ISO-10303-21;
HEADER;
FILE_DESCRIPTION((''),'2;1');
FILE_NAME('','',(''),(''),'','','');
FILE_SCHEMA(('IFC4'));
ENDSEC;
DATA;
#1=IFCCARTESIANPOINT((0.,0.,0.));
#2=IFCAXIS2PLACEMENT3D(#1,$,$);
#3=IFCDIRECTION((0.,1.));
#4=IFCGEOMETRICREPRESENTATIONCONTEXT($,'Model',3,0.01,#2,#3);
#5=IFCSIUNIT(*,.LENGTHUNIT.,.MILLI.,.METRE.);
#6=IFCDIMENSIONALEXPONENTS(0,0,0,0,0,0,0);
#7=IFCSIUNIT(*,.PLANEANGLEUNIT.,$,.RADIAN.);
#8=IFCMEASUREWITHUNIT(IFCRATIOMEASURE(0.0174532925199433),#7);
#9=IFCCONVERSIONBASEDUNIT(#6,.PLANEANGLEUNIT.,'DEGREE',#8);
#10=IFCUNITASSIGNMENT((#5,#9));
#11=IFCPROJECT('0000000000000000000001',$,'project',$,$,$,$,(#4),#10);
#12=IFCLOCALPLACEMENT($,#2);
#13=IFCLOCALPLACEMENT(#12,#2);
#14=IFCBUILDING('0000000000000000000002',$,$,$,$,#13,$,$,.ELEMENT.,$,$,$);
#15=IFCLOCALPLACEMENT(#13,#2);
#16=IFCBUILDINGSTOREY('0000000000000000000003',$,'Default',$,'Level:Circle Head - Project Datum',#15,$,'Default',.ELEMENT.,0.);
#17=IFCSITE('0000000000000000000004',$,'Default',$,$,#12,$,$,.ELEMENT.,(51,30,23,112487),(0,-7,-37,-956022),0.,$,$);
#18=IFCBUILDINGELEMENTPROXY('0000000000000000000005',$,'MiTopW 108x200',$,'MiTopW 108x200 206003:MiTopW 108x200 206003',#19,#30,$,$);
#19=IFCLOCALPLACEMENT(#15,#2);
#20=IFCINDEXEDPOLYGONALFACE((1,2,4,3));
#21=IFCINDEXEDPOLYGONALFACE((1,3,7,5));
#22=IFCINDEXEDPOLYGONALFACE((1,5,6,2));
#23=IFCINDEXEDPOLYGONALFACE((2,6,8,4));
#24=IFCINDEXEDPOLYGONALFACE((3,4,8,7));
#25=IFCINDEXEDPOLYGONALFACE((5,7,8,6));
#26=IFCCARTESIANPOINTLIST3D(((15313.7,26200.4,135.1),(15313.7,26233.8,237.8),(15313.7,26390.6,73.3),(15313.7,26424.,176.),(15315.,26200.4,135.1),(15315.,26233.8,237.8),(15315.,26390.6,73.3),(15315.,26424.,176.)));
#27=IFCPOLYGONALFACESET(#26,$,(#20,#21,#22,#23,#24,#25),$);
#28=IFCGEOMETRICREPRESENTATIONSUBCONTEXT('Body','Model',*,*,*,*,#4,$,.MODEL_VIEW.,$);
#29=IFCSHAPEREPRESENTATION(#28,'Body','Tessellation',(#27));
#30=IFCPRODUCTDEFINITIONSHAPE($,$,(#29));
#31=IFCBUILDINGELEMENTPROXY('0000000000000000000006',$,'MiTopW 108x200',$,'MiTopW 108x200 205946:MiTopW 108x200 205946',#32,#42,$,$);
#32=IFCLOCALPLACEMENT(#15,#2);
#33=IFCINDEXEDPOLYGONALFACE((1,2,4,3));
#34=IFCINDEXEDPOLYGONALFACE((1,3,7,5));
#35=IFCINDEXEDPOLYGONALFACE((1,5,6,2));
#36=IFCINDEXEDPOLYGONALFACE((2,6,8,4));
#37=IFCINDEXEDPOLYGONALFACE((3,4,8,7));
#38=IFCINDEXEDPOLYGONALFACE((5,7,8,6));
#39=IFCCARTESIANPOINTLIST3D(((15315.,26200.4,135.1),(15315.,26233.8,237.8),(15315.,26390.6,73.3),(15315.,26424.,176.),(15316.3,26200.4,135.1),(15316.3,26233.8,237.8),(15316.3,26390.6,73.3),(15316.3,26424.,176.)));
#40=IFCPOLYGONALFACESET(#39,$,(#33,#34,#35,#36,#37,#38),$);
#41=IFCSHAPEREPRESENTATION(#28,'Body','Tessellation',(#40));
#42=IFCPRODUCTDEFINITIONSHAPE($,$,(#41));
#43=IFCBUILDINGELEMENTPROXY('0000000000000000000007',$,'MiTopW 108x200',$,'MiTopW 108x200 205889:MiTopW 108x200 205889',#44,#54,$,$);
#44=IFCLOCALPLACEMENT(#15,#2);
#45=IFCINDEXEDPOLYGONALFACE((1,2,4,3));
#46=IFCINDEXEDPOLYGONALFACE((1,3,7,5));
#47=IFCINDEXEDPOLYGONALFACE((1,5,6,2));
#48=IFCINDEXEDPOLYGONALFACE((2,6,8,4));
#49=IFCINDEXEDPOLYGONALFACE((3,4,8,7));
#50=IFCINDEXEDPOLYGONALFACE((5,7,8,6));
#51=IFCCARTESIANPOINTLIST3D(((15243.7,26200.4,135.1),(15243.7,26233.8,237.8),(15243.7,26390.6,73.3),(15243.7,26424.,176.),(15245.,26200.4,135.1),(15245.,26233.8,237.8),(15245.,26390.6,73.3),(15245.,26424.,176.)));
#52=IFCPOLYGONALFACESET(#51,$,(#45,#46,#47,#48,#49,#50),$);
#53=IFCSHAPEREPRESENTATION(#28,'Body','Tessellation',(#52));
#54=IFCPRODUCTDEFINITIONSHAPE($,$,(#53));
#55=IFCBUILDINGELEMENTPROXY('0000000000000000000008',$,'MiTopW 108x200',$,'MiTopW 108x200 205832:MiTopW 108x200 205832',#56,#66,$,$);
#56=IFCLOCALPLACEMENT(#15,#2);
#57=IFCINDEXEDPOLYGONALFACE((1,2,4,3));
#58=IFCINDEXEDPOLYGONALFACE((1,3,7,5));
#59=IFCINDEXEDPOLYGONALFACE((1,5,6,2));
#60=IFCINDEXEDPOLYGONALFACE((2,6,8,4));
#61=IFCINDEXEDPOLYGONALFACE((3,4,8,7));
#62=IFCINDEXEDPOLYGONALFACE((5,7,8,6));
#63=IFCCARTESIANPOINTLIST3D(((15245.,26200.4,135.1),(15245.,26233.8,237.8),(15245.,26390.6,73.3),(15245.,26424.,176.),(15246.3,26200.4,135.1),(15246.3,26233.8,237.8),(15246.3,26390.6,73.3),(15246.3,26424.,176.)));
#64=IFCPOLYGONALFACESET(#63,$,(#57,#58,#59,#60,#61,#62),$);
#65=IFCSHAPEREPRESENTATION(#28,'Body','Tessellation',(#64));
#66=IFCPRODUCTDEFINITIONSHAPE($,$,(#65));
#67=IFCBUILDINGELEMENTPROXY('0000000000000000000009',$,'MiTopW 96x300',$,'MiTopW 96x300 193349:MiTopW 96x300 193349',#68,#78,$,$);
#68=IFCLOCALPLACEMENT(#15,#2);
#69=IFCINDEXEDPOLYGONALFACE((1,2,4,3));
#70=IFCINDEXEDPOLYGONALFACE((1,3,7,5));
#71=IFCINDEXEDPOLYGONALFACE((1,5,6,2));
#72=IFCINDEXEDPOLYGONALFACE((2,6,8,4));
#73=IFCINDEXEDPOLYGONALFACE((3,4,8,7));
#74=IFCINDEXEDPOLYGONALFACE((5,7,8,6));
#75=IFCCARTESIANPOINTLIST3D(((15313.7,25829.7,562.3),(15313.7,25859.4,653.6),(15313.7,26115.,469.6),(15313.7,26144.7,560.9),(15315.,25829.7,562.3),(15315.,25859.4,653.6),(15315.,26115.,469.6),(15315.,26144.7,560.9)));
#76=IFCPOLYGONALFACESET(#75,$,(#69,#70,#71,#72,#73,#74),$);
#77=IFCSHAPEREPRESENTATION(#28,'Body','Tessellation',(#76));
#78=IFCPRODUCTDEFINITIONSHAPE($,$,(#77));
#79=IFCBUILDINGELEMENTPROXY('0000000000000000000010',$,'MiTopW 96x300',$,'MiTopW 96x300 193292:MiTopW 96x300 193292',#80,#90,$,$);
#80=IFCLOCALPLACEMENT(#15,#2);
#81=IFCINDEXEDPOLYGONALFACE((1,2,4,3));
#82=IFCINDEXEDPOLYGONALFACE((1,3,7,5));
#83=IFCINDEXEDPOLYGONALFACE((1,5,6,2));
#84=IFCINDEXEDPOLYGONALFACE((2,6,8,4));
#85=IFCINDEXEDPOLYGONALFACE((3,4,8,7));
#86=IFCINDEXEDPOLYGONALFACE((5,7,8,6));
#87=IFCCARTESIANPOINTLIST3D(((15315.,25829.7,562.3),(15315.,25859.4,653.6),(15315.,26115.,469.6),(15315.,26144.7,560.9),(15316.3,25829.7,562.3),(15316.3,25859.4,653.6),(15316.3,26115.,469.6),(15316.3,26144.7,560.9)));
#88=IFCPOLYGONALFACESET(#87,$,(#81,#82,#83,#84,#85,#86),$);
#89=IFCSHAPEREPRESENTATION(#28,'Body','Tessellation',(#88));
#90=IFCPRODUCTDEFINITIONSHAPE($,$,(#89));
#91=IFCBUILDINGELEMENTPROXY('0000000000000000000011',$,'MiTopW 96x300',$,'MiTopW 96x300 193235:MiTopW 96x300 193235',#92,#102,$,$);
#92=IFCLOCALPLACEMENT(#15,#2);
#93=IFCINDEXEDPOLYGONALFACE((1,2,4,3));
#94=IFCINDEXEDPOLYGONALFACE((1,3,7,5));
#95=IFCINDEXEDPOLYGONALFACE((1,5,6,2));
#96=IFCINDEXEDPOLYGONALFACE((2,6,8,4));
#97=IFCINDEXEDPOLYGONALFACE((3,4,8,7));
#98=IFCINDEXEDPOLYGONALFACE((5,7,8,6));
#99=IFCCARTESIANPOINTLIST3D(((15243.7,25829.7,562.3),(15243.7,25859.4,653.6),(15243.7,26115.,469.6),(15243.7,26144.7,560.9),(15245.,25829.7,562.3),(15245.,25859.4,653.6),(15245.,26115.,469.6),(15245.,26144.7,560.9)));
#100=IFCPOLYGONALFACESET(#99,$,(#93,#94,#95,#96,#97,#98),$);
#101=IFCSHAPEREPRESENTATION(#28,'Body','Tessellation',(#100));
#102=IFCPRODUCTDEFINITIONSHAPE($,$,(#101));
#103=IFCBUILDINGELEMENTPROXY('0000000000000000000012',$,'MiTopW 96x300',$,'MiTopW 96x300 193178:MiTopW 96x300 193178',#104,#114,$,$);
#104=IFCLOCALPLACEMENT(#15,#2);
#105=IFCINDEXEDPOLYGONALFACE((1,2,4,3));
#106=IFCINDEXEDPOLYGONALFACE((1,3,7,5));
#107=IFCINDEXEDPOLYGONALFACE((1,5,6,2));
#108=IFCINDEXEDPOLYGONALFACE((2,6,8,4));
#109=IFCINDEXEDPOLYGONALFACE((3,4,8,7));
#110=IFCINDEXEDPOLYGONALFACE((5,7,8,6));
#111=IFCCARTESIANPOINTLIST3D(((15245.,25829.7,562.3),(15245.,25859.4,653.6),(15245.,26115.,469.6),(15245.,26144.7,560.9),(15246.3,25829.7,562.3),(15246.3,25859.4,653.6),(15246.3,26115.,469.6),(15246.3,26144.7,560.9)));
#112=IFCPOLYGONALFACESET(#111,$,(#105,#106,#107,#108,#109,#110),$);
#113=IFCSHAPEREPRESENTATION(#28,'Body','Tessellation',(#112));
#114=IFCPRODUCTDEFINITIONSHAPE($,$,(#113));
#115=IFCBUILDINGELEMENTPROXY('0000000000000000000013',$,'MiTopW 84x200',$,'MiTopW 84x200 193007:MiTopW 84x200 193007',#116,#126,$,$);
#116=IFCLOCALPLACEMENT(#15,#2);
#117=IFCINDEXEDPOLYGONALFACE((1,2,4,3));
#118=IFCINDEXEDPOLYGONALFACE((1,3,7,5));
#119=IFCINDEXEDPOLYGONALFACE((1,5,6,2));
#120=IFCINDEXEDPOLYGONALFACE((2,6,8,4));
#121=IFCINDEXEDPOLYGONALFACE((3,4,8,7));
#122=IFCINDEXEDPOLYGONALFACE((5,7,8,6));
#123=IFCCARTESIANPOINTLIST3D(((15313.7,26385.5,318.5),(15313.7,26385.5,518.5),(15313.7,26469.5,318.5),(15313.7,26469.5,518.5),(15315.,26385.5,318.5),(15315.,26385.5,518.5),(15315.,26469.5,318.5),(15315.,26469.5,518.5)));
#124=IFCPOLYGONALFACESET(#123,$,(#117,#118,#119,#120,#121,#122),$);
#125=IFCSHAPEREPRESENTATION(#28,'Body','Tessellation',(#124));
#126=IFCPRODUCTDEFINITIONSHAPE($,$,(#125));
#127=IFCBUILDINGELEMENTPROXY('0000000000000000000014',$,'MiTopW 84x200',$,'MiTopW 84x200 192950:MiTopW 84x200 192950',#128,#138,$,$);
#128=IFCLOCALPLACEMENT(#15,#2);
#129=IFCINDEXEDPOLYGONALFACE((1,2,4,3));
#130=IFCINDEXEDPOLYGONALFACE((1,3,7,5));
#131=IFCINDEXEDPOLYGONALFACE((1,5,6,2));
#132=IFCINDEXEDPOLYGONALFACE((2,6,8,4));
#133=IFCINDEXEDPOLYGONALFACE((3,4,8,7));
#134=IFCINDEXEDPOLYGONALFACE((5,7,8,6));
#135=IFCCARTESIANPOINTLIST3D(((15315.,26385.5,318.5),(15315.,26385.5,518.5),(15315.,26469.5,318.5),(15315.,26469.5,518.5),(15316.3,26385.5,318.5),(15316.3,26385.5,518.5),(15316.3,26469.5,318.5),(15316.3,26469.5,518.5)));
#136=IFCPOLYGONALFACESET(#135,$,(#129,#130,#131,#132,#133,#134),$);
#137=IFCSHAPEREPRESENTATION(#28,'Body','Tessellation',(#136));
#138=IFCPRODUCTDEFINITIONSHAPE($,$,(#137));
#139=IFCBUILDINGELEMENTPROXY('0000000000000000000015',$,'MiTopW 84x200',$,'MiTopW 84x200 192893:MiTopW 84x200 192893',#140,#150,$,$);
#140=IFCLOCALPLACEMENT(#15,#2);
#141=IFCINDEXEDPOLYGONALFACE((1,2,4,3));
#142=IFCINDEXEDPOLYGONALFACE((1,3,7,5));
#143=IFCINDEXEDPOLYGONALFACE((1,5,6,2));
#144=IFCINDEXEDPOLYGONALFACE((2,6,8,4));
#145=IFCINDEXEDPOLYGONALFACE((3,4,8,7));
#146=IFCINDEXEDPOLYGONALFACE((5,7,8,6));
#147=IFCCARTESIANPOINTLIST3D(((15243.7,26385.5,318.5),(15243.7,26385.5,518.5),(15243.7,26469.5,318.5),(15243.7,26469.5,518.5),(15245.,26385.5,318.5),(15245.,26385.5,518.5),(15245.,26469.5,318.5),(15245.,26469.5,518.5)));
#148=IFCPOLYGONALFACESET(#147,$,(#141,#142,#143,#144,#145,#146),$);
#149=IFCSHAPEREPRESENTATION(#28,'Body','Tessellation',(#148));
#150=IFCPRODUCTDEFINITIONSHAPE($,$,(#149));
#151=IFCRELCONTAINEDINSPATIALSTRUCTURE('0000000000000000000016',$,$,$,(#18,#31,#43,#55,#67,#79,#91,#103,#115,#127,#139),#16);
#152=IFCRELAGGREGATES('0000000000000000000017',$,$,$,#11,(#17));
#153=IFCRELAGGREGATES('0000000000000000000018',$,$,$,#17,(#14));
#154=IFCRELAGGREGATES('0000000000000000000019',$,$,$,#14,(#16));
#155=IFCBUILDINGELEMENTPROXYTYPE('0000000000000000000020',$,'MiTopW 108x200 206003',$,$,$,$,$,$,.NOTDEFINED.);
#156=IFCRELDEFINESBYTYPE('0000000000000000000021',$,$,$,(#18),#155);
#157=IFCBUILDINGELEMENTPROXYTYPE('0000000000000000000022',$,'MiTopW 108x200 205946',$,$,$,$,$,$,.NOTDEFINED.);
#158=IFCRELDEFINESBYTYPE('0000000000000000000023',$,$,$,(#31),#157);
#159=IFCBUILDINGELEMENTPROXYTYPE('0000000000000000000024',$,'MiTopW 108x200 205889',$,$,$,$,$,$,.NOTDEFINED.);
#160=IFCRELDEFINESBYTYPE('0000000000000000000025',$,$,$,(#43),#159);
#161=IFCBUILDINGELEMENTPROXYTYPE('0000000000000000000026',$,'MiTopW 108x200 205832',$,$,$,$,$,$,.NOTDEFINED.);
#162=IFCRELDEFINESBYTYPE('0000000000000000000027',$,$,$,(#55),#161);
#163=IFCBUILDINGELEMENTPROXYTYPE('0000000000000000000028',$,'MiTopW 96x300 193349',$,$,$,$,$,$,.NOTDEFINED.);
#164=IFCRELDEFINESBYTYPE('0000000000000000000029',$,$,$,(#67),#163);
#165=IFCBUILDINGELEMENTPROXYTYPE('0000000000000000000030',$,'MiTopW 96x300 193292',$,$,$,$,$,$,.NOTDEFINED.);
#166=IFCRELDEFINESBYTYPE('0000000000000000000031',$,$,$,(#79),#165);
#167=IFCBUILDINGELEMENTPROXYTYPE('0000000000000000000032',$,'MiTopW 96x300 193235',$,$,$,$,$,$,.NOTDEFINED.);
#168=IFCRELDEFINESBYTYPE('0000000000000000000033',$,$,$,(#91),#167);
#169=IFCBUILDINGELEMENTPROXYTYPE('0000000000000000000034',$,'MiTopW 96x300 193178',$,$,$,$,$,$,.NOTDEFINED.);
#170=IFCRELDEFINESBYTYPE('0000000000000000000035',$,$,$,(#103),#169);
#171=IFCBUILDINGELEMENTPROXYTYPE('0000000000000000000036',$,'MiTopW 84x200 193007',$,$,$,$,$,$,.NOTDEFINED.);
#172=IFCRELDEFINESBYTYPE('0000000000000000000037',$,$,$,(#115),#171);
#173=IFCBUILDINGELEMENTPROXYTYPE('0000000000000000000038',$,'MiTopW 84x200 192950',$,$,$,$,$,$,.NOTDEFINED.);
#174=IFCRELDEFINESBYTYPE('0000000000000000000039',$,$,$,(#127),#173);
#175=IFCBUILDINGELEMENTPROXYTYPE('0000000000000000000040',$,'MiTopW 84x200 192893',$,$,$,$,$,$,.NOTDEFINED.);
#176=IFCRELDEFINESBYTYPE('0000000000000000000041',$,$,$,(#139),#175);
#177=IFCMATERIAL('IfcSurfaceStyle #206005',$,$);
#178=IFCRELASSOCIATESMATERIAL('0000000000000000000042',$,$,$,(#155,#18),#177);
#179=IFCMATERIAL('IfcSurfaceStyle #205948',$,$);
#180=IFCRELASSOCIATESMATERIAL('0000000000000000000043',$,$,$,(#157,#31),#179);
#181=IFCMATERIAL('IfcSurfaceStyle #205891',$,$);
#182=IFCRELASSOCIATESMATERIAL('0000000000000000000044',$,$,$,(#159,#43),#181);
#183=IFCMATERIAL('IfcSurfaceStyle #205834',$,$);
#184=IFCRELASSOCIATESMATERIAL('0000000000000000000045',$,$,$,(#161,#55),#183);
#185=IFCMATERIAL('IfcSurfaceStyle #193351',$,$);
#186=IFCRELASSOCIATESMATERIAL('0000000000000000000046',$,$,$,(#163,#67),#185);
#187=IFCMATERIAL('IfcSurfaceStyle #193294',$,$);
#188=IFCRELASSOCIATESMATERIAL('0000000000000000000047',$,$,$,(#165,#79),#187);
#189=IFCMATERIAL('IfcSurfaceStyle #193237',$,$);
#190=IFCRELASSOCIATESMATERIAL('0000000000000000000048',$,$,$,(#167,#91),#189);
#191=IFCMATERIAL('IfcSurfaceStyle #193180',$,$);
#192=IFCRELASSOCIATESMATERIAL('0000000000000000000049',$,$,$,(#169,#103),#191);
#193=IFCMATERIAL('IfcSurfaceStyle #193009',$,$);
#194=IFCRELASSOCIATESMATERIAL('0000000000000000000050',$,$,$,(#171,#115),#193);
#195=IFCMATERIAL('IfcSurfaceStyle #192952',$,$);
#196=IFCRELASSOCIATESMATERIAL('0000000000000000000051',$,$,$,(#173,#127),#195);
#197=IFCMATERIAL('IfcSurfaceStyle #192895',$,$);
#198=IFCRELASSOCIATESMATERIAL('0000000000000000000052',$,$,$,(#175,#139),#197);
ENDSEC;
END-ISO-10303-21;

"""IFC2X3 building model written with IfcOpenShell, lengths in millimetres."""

from ifc_helpers import new_model, entity, si_unit, converted_unit, direction, frame, frame_2d, origin, place, context, subcontext, project, spatial, polyline, rectangle, outline, extrude, source, transform, mapped, material, type_object, type_shapes, element, save


model = new_model("IFC2X3")

# Units and contexts
model_context = context("Model", 3, precision=0.01, world=origin(), true_north=direction((0.0, 1.0)))
body_context = subcontext(model_context, "Body", "Model", "MODEL_VIEW")
ifc_project = project(units=[si_unit("LENGTHUNIT", "METRE", prefix="MILLI"), converted_unit("PLANEANGLEUNIT", "DEGREE", entity("IfcRatioMeasure", 0.0174532925199433), si_unit("PLANEANGLEUNIT", "RADIAN"), dimensions=[0, 0, 0, 0, 0, 0, 0])], contexts=[model_context])

# Site, building, storey
site_placement = place(None, origin())
site = spatial("IfcSite", under=ifc_project, at=site_placement, Name="Default", CompositionType="ELEMENT", RefLatitude=(51, 30, 23, 112487), RefLongitude=(0, -7, -37, -956022), RefElevation=0.0)
building_placement = place(site_placement, origin())
building = spatial("IfcBuilding", under=site, at=building_placement, CompositionType="ELEMENT")
storey_placement = place(building_placement, origin())
storey = spatial("IfcBuildingStorey", under=building, at=storey_placement, Name="Default", ObjectType="Level:Circle Head - Project Datum", LongName="Default", CompositionType="ELEMENT", Elevation=0.0)

# Building element proxies
ifc_material_1 = material(Name="IfcSurfaceStyle #206005")
building_element_proxy_type_1 = type_object("IfcBuildingElementProxyType", Name="MiTopW 108x200 206003", PredefinedType="NOTDEFINED", material=ifc_material_1)
shared_shape_1 = source(origin(), body_context, "Body", "SweptSolid", [
    extrude(outline(polyline([(-100.0, -54.0), (100.0, -54.0), (100.0, 54.0), (-100.0, 54.0), (-100.0, -54.0)])), frame((100.0, 54.0, 0.0), z_axis=(0.0, 0.0, 1.0), x_axis=(-1.0, 0.0, 0.0)), (0.0, 0.0, 1.0), 1.3),
])
type_shapes(building_element_proxy_type_1, [shared_shape_1])
proxy_1_placement = place(building_placement, frame((15315.0, 26390.6, 73.3), z_axis=(-1.0, 0.0, 0.0), x_axis=(0.0, -0.951057, 0.309017)))
element("IfcBuildingElementProxy", 1, at=proxy_1_placement, inside=storey, type_object=building_element_proxy_type_1, material=ifc_material_1, Name="MiTopW 108x200", ObjectType="MiTopW 108x200 206003:MiTopW 108x200 206003", context=body_context, shape_type="MappedRepresentation", body=[
    mapped(shared_shape_1, transform((0.0, 0.0, 0.0), scale=1.0)),
])
ifc_material_2 = material(Name="IfcSurfaceStyle #205948")
building_element_proxy_type_2 = type_object("IfcBuildingElementProxyType", Name="MiTopW 108x200 205946", PredefinedType="NOTDEFINED", material=ifc_material_2)
shared_shape_2 = source(origin(), body_context, "Body", "SweptSolid", [
    extrude(outline(polyline([(-100.0, -54.0), (100.0, -54.0), (100.0, 54.0), (-100.0, 54.0), (-100.0, -54.0)])), frame((100.0, 54.0, 0.0), z_axis=(0.0, 0.0, 1.0), x_axis=(-1.0, 0.0, 0.0)), (0.0, 0.0, 1.0), 1.3),
])
type_shapes(building_element_proxy_type_2, [shared_shape_2])
proxy_2_placement = place(building_placement, frame((15316.3, 26390.6, 73.3), z_axis=(-1.0, 0.0, 0.0), x_axis=(0.0, -0.951057, 0.309017)))
element("IfcBuildingElementProxy", 2, at=proxy_2_placement, inside=storey, type_object=building_element_proxy_type_2, material=ifc_material_2, Name="MiTopW 108x200", ObjectType="MiTopW 108x200 205946:MiTopW 108x200 205946", context=body_context, shape_type="MappedRepresentation", body=[
    mapped(shared_shape_2, transform((0.0, 0.0, 0.0), scale=1.0)),
])
ifc_material_3 = material(Name="IfcSurfaceStyle #205891")
building_element_proxy_type_3 = type_object("IfcBuildingElementProxyType", Name="MiTopW 108x200 205889", PredefinedType="NOTDEFINED", material=ifc_material_3)
shared_shape_3 = source(origin(), body_context, "Body", "SweptSolid", [
    extrude(outline(polyline([(-100.0, -54.0), (100.0, -54.0), (100.0, 54.0), (-100.0, 54.0), (-100.0, -54.0)])), frame((100.0, 54.0, 0.0), z_axis=(0.0, 0.0, 1.0), x_axis=(-1.0, 0.0, 0.0)), (0.0, 0.0, 1.0), 1.3),
])
type_shapes(building_element_proxy_type_3, [shared_shape_3])
proxy_3_placement = place(building_placement, frame((15245.0, 26390.6, 73.3), z_axis=(-1.0, 0.0, 0.0), x_axis=(0.0, -0.951057, 0.309017)))
element("IfcBuildingElementProxy", 3, at=proxy_3_placement, inside=storey, type_object=building_element_proxy_type_3, material=ifc_material_3, Name="MiTopW 108x200", ObjectType="MiTopW 108x200 205889:MiTopW 108x200 205889", context=body_context, shape_type="MappedRepresentation", body=[
    mapped(shared_shape_3, transform((0.0, 0.0, 0.0), scale=1.0)),
])
ifc_material_4 = material(Name="IfcSurfaceStyle #205834")
building_element_proxy_type_4 = type_object("IfcBuildingElementProxyType", Name="MiTopW 108x200 205832", PredefinedType="NOTDEFINED", material=ifc_material_4)
shared_shape_4 = source(origin(), body_context, "Body", "SweptSolid", [
    extrude(outline(polyline([(-100.0, -54.0), (100.0, -54.0), (100.0, 54.0), (-100.0, 54.0), (-100.0, -54.0)])), frame((100.0, 54.0, 0.0), z_axis=(0.0, 0.0, 1.0), x_axis=(-1.0, 0.0, 0.0)), (0.0, 0.0, 1.0), 1.3),
])
type_shapes(building_element_proxy_type_4, [shared_shape_4])
proxy_4_placement = place(building_placement, frame((15246.3, 26390.6, 73.3), z_axis=(-1.0, 0.0, 0.0), x_axis=(0.0, -0.951057, 0.309017)))
element("IfcBuildingElementProxy", 4, at=proxy_4_placement, inside=storey, type_object=building_element_proxy_type_4, material=ifc_material_4, Name="MiTopW 108x200", ObjectType="MiTopW 108x200 205832:MiTopW 108x200 205832", context=body_context, shape_type="MappedRepresentation", body=[
    mapped(shared_shape_4, transform((0.0, 0.0, 0.0), scale=1.0)),
])
ifc_material_5 = material(Name="IfcSurfaceStyle #193351")
building_element_proxy_type_5 = type_object("IfcBuildingElementProxyType", Name="MiTopW 96x300 193349", PredefinedType="NOTDEFINED", material=ifc_material_5)
shared_shape_5 = source(origin(), body_context, "Body", "SweptSolid", [
    extrude(outline(polyline([(-150.0, -48.0), (150.0, -48.0), (150.0, 48.0), (-150.0, 48.0), (-150.0, -48.0)])), frame((150.0, 48.0, 0.0), z_axis=(0.0, 0.0, 1.0), x_axis=(-1.0, 0.0, 0.0)), (0.0, 0.0, 1.0), 1.3),
])
type_shapes(building_element_proxy_type_5, [shared_shape_5])
proxy_5_placement = place(building_placement, frame((15315.0, 26115.0, 469.6), z_axis=(-1.0, 0.0, 0.0), x_axis=(0.0, -0.951057, 0.309017)))
element("IfcBuildingElementProxy", 5, at=proxy_5_placement, inside=storey, type_object=building_element_proxy_type_5, material=ifc_material_5, Name="MiTopW 96x300", ObjectType="MiTopW 96x300 193349:MiTopW 96x300 193349", context=body_context, shape_type="MappedRepresentation", body=[
    mapped(shared_shape_5, transform((0.0, 0.0, 0.0), scale=1.0)),
])
ifc_material_6 = material(Name="IfcSurfaceStyle #193294")
building_element_proxy_type_6 = type_object("IfcBuildingElementProxyType", Name="MiTopW 96x300 193292", PredefinedType="NOTDEFINED", material=ifc_material_6)
shared_shape_6 = source(origin(), body_context, "Body", "SweptSolid", [
    extrude(outline(polyline([(-150.0, -48.0), (150.0, -48.0), (150.0, 48.0), (-150.0, 48.0), (-150.0, -48.0)])), frame((150.0, 48.0, 0.0), z_axis=(0.0, 0.0, 1.0), x_axis=(-1.0, 0.0, 0.0)), (0.0, 0.0, 1.0), 1.3),
])
type_shapes(building_element_proxy_type_6, [shared_shape_6])
proxy_6_placement = place(building_placement, frame((15316.3, 26115.0, 469.6), z_axis=(-1.0, 0.0, 0.0), x_axis=(0.0, -0.951057, 0.309017)))
element("IfcBuildingElementProxy", 6, at=proxy_6_placement, inside=storey, type_object=building_element_proxy_type_6, material=ifc_material_6, Name="MiTopW 96x300", ObjectType="MiTopW 96x300 193292:MiTopW 96x300 193292", context=body_context, shape_type="MappedRepresentation", body=[
    mapped(shared_shape_6, transform((0.0, 0.0, 0.0), scale=1.0)),
])
ifc_material_7 = material(Name="IfcSurfaceStyle #193237")
building_element_proxy_type_7 = type_object("IfcBuildingElementProxyType", Name="MiTopW 96x300 193235", PredefinedType="NOTDEFINED", material=ifc_material_7)
shared_shape_7 = source(origin(), body_context, "Body", "SweptSolid", [
    extrude(outline(polyline([(-150.0, -48.0), (150.0, -48.0), (150.0, 48.0), (-150.0, 48.0), (-150.0, -48.0)])), frame((150.0, 48.0, 0.0), z_axis=(0.0, 0.0, 1.0), x_axis=(-1.0, 0.0, 0.0)), (0.0, 0.0, 1.0), 1.3),
])
type_shapes(building_element_proxy_type_7, [shared_shape_7])
proxy_7_placement = place(building_placement, frame((15245.0, 26115.0, 469.6), z_axis=(-1.0, 0.0, 0.0), x_axis=(0.0, -0.951057, 0.309017)))
element("IfcBuildingElementProxy", 7, at=proxy_7_placement, inside=storey, type_object=building_element_proxy_type_7, material=ifc_material_7, Name="MiTopW 96x300", ObjectType="MiTopW 96x300 193235:MiTopW 96x300 193235", context=body_context, shape_type="MappedRepresentation", body=[
    mapped(shared_shape_7, transform((0.0, 0.0, 0.0), scale=1.0)),
])
ifc_material_8 = material(Name="IfcSurfaceStyle #193180")
building_element_proxy_type_8 = type_object("IfcBuildingElementProxyType", Name="MiTopW 96x300 193178", PredefinedType="NOTDEFINED", material=ifc_material_8)
shared_shape_8 = source(origin(), body_context, "Body", "SweptSolid", [
    extrude(outline(polyline([(-150.0, -48.0), (150.0, -48.0), (150.0, 48.0), (-150.0, 48.0), (-150.0, -48.0)])), frame((150.0, 48.0, 0.0), z_axis=(0.0, 0.0, 1.0), x_axis=(-1.0, 0.0, 0.0)), (0.0, 0.0, 1.0), 1.3),
])
type_shapes(building_element_proxy_type_8, [shared_shape_8])
proxy_8_placement = place(building_placement, frame((15246.3, 26115.0, 469.6), z_axis=(-1.0, 0.0, 0.0), x_axis=(0.0, -0.951057, 0.309017)))
element("IfcBuildingElementProxy", 8, at=proxy_8_placement, inside=storey, type_object=building_element_proxy_type_8, material=ifc_material_8, Name="MiTopW 96x300", ObjectType="MiTopW 96x300 193178:MiTopW 96x300 193178", context=body_context, shape_type="MappedRepresentation", body=[
    mapped(shared_shape_8, transform((0.0, 0.0, 0.0), scale=1.0)),
])
ifc_material_9 = material(Name="IfcSurfaceStyle #193009")
building_element_proxy_type_9 = type_object("IfcBuildingElementProxyType", Name="MiTopW 84x200 193007", PredefinedType="NOTDEFINED", material=ifc_material_9)
shared_shape_9 = source(origin(), body_context, "Body", "SweptSolid", [
    extrude(rectangle(XDim=200.0, YDim=84.0, at=frame_2d((0.0, 0.0), x_axis=(1.0, 0.0))), frame((100.0, 42.0, 0.0), z_axis=(0.0, 0.0, 1.0), x_axis=(-1.0, 0.0, 0.0)), (0.0, 0.0, 1.0), 1.3),
])
type_shapes(building_element_proxy_type_9, [shared_shape_9])
proxy_9_placement = place(building_placement, frame((15315.0, 26469.5, 518.5), z_axis=(-1.0, 0.0, 0.0), x_axis=(0.0, 0.0, -1.0)))
element("IfcBuildingElementProxy", 9, at=proxy_9_placement, inside=storey, type_object=building_element_proxy_type_9, material=ifc_material_9, Name="MiTopW 84x200", ObjectType="MiTopW 84x200 193007:MiTopW 84x200 193007", context=body_context, shape_type="MappedRepresentation", body=[
    mapped(shared_shape_9, transform((0.0, 0.0, 0.0), scale=1.0)),
])
ifc_material_10 = material(Name="IfcSurfaceStyle #192952")
building_element_proxy_type_10 = type_object("IfcBuildingElementProxyType", Name="MiTopW 84x200 192950", PredefinedType="NOTDEFINED", material=ifc_material_10)
shared_shape_10 = source(origin(), body_context, "Body", "SweptSolid", [
    extrude(rectangle(XDim=200.0, YDim=84.0, at=frame_2d((0.0, 0.0), x_axis=(1.0, 0.0))), frame((100.0, 42.0, 0.0), z_axis=(0.0, 0.0, 1.0), x_axis=(-1.0, 0.0, 0.0)), (0.0, 0.0, 1.0), 1.3),
])
type_shapes(building_element_proxy_type_10, [shared_shape_10])
proxy_10_placement = place(building_placement, frame((15316.3, 26469.5, 518.5), z_axis=(-1.0, 0.0, 0.0), x_axis=(0.0, 0.0, -1.0)))
element("IfcBuildingElementProxy", 10, at=proxy_10_placement, inside=storey, type_object=building_element_proxy_type_10, material=ifc_material_10, Name="MiTopW 84x200", ObjectType="MiTopW 84x200 192950:MiTopW 84x200 192950", context=body_context, shape_type="MappedRepresentation", body=[
    mapped(shared_shape_10, transform((0.0, 0.0, 0.0), scale=1.0)),
])
ifc_material_11 = material(Name="IfcSurfaceStyle #192895")
building_element_proxy_type_11 = type_object("IfcBuildingElementProxyType", Name="MiTopW 84x200 192893", PredefinedType="NOTDEFINED", material=ifc_material_11)
shared_shape_11 = source(origin(), body_context, "Body", "SweptSolid", [
    extrude(rectangle(XDim=200.0, YDim=84.0, at=frame_2d((0.0, 0.0), x_axis=(1.0, 0.0))), frame((100.0, 42.0, 0.0), z_axis=(0.0, 0.0, 1.0), x_axis=(-1.0, 0.0, 0.0)), (0.0, 0.0, 1.0), 1.3),
])
type_shapes(building_element_proxy_type_11, [shared_shape_11])
proxy_11_placement = place(building_placement, frame((15245.0, 26469.5, 518.5), z_axis=(-1.0, 0.0, 0.0), x_axis=(0.0, 0.0, -1.0)))
element("IfcBuildingElementProxy", 11, at=proxy_11_placement, inside=storey, type_object=building_element_proxy_type_11, material=ifc_material_11, Name="MiTopW 84x200", ObjectType="MiTopW 84x200 192893:MiTopW 84x200 192893", context=body_context, shape_type="MappedRepresentation", body=[
    mapped(shared_shape_11, transform((0.0, 0.0, 0.0), scale=1.0)),
])

save(model, "model.ifc")
